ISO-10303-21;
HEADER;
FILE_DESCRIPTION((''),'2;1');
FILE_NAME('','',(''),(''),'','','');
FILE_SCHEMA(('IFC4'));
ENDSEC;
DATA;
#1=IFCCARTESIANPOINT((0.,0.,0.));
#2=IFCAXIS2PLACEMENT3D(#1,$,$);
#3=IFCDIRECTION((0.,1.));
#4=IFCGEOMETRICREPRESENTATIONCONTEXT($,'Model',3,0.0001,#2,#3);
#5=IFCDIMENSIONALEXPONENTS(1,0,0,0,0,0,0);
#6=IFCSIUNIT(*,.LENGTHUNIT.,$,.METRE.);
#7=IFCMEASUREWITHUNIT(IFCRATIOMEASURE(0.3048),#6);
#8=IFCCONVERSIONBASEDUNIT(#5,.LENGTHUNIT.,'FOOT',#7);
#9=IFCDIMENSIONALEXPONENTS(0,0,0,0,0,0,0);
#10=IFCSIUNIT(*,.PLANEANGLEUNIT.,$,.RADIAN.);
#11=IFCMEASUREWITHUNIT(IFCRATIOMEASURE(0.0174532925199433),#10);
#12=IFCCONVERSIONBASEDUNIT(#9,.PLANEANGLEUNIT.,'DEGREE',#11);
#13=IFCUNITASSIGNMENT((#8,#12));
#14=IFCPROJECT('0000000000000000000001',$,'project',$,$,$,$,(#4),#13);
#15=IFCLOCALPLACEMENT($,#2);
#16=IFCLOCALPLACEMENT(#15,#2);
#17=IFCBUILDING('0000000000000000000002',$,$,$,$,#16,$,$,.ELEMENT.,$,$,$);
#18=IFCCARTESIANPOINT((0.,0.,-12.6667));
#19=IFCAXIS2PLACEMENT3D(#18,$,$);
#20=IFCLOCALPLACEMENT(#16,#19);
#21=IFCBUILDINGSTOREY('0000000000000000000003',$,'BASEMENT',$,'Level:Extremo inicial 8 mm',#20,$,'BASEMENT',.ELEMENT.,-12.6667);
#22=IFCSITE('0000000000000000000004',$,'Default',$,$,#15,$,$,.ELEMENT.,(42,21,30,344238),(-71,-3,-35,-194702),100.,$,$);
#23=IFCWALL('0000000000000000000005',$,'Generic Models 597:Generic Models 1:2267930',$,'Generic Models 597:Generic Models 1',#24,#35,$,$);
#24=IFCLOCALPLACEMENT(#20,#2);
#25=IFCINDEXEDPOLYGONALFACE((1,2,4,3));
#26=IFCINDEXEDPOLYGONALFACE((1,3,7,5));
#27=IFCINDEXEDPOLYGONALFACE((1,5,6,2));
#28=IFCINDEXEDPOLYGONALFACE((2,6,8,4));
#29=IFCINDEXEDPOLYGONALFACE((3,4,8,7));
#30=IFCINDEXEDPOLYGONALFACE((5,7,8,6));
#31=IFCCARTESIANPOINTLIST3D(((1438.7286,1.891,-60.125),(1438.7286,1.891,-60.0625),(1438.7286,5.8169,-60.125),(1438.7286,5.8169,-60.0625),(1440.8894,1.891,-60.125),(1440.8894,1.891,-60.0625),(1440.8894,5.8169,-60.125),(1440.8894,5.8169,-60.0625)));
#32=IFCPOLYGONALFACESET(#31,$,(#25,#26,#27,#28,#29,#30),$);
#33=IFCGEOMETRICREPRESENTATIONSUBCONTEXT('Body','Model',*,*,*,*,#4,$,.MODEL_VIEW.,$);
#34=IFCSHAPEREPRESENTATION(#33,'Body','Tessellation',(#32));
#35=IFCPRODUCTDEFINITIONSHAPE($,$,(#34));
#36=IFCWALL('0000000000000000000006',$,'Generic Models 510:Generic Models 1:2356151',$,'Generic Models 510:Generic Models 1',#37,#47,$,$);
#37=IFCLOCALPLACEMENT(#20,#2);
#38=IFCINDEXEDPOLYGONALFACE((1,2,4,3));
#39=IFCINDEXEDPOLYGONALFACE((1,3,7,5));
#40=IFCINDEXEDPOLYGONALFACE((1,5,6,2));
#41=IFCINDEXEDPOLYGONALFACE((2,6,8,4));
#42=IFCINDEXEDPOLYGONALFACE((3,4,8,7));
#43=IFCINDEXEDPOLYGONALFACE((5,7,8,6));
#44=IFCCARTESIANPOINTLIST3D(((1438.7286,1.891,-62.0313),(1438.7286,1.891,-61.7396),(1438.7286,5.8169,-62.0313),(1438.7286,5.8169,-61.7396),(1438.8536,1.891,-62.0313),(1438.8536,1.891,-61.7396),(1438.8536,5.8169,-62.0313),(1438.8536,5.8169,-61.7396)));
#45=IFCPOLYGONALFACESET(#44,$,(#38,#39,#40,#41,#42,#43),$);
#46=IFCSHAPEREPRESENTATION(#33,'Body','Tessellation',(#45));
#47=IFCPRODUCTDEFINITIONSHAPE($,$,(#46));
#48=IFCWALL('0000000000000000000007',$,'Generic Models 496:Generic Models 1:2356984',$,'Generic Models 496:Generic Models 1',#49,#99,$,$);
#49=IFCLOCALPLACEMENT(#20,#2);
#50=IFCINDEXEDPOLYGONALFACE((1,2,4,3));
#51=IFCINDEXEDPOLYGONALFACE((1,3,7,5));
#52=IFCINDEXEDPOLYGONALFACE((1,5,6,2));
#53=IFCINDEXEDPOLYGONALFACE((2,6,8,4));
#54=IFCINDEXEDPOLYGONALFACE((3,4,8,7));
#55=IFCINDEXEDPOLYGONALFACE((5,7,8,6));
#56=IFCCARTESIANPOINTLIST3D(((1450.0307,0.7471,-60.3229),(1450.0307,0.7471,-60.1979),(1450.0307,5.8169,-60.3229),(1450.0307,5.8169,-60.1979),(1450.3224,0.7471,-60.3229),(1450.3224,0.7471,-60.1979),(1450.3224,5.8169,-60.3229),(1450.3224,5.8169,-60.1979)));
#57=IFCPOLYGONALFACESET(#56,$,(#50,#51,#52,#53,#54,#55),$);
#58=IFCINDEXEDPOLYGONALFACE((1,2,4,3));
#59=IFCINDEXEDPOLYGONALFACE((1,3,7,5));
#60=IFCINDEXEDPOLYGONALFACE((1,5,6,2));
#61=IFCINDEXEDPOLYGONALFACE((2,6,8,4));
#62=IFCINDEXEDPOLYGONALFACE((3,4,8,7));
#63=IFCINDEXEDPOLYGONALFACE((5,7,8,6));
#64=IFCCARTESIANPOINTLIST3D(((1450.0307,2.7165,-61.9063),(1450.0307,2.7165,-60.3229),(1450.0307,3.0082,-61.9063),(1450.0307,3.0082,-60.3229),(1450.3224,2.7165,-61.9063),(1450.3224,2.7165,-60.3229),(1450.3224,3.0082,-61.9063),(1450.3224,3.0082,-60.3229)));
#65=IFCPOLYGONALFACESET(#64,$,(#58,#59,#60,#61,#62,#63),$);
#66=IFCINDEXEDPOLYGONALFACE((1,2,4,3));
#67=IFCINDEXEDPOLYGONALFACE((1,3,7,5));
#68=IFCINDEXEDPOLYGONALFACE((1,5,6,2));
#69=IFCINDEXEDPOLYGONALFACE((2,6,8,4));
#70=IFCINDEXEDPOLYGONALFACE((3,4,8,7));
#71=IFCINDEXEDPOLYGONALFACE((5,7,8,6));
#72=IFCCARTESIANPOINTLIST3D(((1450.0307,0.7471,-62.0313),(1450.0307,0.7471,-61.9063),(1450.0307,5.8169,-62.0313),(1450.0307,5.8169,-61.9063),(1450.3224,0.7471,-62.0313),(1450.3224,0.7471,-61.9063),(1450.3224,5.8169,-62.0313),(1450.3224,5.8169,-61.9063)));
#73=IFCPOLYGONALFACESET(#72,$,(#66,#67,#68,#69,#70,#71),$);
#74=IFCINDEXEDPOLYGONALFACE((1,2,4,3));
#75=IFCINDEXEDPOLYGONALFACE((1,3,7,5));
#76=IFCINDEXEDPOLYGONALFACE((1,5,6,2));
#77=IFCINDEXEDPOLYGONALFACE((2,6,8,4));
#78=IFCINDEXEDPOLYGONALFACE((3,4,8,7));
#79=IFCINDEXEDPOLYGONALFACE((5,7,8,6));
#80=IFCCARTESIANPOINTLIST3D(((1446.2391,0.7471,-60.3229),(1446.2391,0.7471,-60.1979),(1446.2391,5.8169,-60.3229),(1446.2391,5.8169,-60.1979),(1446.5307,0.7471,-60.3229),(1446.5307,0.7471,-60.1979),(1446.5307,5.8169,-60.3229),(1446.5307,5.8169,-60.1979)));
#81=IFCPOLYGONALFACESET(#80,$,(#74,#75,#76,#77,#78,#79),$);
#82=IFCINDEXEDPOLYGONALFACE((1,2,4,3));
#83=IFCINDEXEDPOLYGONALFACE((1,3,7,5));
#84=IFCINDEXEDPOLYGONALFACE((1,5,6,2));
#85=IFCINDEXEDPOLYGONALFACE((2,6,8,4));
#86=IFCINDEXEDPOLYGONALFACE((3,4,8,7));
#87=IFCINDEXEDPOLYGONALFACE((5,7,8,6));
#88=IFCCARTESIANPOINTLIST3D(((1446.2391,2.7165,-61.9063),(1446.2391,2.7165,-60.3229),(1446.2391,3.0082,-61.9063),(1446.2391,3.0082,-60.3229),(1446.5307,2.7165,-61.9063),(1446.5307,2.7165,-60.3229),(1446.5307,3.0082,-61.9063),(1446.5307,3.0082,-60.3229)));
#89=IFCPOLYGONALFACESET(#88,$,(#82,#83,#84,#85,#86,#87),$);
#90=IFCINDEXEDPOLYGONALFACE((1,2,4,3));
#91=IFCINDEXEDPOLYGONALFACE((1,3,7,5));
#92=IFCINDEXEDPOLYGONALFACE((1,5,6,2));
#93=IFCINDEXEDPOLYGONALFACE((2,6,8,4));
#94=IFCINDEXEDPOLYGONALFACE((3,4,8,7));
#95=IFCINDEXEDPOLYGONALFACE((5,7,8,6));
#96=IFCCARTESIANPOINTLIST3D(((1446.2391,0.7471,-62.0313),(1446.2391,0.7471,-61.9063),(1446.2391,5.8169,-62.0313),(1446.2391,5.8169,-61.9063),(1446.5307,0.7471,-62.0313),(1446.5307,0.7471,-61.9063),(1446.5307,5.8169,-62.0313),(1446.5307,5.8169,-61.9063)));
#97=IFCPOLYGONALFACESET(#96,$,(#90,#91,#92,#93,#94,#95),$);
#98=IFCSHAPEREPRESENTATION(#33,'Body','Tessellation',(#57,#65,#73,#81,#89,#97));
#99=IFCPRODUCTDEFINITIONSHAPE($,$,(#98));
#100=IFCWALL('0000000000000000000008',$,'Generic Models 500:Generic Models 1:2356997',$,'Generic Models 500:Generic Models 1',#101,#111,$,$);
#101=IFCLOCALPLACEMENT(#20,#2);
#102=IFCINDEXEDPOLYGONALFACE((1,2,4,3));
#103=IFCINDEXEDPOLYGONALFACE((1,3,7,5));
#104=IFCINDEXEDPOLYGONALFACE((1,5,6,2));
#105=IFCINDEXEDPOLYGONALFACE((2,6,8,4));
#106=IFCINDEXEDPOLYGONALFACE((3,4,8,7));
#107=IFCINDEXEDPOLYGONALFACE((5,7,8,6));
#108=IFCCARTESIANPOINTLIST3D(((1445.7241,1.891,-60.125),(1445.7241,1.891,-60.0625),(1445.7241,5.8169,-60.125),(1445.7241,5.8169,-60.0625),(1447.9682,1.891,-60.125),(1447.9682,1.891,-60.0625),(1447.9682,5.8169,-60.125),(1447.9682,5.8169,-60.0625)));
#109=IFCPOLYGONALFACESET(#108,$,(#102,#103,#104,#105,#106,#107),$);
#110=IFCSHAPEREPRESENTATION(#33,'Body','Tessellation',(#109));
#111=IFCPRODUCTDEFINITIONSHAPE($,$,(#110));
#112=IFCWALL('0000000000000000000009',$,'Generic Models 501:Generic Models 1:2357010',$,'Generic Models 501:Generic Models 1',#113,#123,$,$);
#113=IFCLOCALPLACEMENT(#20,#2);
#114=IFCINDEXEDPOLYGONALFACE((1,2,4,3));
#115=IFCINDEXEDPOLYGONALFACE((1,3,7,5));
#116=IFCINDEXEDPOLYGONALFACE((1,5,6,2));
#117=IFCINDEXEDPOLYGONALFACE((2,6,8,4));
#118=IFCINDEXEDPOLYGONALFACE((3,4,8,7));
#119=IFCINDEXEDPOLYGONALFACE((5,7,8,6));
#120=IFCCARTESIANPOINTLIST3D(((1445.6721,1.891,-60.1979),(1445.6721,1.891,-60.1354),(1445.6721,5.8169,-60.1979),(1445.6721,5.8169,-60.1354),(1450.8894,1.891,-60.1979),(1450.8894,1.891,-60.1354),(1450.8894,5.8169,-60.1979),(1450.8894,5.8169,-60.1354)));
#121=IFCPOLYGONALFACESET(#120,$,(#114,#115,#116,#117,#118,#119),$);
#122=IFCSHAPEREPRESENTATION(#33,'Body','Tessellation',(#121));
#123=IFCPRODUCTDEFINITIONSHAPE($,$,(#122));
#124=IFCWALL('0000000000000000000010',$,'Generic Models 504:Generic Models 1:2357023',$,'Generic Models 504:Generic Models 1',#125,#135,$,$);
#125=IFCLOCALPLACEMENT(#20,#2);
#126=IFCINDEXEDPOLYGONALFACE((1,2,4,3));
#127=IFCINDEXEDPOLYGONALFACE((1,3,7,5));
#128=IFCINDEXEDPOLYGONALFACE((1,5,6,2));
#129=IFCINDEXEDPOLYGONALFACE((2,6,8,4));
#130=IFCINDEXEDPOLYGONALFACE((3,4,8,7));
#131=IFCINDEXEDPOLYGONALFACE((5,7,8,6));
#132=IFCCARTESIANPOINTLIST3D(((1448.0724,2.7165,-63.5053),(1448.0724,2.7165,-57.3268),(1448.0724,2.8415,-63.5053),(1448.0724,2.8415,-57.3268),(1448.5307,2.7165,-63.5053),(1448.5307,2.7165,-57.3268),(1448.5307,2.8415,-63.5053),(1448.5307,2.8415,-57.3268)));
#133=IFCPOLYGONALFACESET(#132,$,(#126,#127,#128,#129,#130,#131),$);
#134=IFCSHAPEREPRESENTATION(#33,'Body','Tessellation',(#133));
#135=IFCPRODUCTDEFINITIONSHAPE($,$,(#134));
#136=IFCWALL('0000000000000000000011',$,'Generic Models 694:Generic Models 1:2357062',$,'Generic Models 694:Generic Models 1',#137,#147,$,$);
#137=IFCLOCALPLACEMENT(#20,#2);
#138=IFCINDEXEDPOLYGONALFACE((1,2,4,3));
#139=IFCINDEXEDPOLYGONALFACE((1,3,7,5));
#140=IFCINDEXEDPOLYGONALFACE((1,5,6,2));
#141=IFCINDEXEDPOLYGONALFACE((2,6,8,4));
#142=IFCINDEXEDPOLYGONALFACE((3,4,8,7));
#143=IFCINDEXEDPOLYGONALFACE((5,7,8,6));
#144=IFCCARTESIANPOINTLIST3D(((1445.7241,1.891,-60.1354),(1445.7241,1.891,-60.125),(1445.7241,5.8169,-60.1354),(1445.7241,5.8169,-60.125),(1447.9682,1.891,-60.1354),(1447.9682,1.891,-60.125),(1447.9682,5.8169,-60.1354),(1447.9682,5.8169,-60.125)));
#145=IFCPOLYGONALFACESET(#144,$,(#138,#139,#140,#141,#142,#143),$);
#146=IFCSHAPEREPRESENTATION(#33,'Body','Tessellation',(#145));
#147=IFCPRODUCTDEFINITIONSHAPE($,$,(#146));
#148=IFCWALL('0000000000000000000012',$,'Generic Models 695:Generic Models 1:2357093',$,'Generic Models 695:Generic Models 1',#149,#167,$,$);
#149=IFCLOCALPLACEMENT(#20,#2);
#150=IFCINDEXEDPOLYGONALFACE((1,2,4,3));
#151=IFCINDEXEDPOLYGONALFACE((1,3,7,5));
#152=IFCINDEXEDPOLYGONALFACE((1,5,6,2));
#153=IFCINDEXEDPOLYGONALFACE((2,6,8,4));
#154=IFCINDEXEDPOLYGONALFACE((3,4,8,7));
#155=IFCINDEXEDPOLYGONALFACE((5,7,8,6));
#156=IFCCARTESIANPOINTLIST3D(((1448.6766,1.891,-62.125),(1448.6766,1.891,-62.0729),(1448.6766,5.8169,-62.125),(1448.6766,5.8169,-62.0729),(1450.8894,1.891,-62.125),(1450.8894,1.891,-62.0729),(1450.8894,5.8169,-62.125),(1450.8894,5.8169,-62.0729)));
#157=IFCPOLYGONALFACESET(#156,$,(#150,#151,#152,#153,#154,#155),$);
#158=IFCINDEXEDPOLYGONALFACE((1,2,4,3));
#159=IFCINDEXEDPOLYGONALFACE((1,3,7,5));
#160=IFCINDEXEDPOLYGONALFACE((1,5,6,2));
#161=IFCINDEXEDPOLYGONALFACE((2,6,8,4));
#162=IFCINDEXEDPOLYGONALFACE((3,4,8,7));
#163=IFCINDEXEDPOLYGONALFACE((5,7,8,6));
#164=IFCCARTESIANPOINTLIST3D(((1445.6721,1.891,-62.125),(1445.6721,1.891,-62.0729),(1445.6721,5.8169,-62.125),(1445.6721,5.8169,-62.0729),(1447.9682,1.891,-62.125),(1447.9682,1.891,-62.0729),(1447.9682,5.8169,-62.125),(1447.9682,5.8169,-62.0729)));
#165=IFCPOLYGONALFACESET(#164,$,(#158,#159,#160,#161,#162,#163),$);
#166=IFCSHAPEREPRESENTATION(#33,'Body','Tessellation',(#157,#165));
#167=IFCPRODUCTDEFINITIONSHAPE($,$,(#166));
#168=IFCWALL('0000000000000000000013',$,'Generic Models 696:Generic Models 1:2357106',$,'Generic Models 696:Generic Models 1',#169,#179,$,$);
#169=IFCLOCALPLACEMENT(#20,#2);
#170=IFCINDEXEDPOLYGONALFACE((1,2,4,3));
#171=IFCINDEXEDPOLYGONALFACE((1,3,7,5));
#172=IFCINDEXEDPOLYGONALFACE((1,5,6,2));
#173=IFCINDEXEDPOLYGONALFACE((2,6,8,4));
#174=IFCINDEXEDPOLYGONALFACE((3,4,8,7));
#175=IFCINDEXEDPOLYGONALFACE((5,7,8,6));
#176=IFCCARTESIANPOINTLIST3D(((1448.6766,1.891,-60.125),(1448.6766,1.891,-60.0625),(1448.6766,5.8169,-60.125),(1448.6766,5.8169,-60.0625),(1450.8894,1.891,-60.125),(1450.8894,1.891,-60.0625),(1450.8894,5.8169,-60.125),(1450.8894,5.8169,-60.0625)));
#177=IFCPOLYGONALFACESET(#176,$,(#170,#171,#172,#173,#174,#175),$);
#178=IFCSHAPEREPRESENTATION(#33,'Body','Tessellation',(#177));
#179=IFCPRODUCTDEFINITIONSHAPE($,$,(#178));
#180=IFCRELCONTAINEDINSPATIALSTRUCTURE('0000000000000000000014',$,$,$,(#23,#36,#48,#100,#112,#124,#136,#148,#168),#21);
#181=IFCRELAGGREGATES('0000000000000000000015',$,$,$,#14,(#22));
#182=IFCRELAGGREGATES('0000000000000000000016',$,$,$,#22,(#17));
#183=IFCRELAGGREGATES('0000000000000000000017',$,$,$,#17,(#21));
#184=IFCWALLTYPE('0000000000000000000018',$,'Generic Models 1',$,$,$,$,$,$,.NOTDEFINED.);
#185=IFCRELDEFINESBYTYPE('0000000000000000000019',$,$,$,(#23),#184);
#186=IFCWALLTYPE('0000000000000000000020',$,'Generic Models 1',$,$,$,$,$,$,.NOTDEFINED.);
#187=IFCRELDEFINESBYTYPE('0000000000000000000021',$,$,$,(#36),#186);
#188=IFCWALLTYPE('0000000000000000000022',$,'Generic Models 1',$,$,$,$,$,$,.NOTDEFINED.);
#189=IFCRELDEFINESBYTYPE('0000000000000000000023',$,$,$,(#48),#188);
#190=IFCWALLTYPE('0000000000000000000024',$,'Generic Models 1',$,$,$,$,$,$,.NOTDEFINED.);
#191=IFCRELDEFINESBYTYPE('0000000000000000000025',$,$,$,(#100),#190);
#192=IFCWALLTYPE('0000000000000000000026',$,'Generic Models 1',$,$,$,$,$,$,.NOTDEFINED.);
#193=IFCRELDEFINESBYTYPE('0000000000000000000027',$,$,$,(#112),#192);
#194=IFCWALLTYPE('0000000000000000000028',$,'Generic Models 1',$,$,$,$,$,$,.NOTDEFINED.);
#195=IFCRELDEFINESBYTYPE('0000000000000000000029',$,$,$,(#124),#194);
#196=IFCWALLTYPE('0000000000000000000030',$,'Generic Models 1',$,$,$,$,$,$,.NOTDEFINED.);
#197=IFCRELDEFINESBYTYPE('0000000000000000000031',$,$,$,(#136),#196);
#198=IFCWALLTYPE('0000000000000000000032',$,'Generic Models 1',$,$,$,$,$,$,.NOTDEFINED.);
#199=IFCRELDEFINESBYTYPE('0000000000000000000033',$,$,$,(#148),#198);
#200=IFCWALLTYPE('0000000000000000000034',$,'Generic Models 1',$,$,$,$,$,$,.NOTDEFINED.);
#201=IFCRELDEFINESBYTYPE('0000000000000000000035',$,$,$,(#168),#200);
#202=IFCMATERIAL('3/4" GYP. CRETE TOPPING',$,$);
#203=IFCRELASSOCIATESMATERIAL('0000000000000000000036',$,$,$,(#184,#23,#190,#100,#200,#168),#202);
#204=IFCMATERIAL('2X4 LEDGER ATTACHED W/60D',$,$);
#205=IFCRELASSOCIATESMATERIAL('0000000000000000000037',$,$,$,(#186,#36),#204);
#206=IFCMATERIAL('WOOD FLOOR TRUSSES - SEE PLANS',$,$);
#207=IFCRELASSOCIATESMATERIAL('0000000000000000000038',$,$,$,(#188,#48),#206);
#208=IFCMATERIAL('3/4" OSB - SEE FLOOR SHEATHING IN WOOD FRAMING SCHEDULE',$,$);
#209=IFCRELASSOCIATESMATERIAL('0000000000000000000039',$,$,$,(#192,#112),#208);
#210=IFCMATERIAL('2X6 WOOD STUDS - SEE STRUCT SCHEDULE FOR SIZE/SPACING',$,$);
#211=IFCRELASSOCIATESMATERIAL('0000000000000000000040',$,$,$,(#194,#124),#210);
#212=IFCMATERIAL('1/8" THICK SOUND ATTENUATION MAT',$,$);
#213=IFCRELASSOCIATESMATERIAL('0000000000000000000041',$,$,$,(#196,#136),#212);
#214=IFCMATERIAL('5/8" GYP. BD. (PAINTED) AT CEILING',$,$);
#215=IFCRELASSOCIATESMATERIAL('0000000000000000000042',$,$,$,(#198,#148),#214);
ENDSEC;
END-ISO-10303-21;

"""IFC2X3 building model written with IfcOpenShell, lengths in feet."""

from ifc_helpers import new_model, entity, si_unit, converted_unit, direction, frame, frame_2d, origin, origin_2d_with_axis, place, context, subcontext, project, spatial, rectangle, extrude, material, type_object, element, save


model = new_model("IFC2X3")

# Units and contexts
model_context = context("Model", 3, precision=0.0001, world=origin(), true_north=direction((0.0, 1.0)))
body_context = subcontext(model_context, "Body", "Model", "MODEL_VIEW")
ifc_project = project(units=[converted_unit("LENGTHUNIT", "FOOT", entity("IfcRatioMeasure", 0.3048), si_unit("LENGTHUNIT", "METRE"), dimensions=[1, 0, 0, 0, 0, 0, 0]), converted_unit("PLANEANGLEUNIT", "DEGREE", entity("IfcRatioMeasure", 0.0174532925199433), si_unit("PLANEANGLEUNIT", "RADIAN"), dimensions=[0, 0, 0, 0, 0, 0, 0])], contexts=[model_context])

# Site, building, storey
site_placement = place(None, origin())
site = spatial("IfcSite", under=ifc_project, at=site_placement, Name="Default", CompositionType="ELEMENT", RefLatitude=(42, 21, 30, 344238), RefLongitude=(-71, -3, -35, -194702), RefElevation=100.0)
building_placement = place(site_placement, origin())
building = spatial("IfcBuilding", under=site, at=building_placement, CompositionType="ELEMENT")
storey_placement = place(building_placement, frame((0.0, 0.0, -12.6667)))
storey = spatial("IfcBuildingStorey", under=building, at=storey_placement, Name="BASEMENT", ObjectType="Level:Extremo inicial 8 mm", LongName="BASEMENT", CompositionType="ELEMENT", Elevation=-12.6667)

# Walls
ifc_material_1 = material(Name="3/4\" GYP. CRETE TOPPING")
wall_type_1 = type_object("IfcWallType", Name="Generic Models 1", PredefinedType="NOTDEFINED", material=ifc_material_1)
wall_1_placement = place(storey_placement, frame((1438.7286, 1.891, -60.125), z_axis=(0.0, 0.0, 1.0), x_axis=(0.0, 1.0, 0.0)))
element("IfcWall", 1, at=wall_1_placement, inside=storey, type_object=wall_type_1, material=ifc_material_1, Name="Generic Models 597:Generic Models 1:2267930", ObjectType="Generic Models 597:Generic Models 1", context=body_context, shape_type="SweptSolid", body=[
    extrude(rectangle(XDim=3.9258, YDim=2.1608, at=origin_2d_with_axis()), frame((1.9629, -1.0804, 0.0)), (0.0, 0.0, 1.0), 0.0625),
])
ifc_material_2 = material(Name="2X4 LEDGER ATTACHED W/60D")
wall_type_2 = type_object("IfcWallType", Name="Generic Models 1", PredefinedType="NOTDEFINED", material=ifc_material_2)
wall_2_placement = place(storey_placement, frame((1438.7286, 1.891, -62.0313), z_axis=(0.0, 0.0, 1.0), x_axis=(0.0, 1.0, 0.0)))
element("IfcWall", 2, at=wall_2_placement, inside=storey, type_object=wall_type_2, material=ifc_material_2, Name="Generic Models 510:Generic Models 1:2356151", ObjectType="Generic Models 510:Generic Models 1", context=body_context, shape_type="SweptSolid", body=[
    extrude(rectangle(XDim=3.9258, YDim=0.125, at=origin_2d_with_axis()), frame((1.9629, -0.0625, 0.0)), (0.0, 0.0, 1.0), 0.2917),
])
ifc_material_3 = material(Name="WOOD FLOOR TRUSSES - SEE PLANS")
wall_type_3 = type_object("IfcWallType", Name="Generic Models 1", PredefinedType="NOTDEFINED", material=ifc_material_3)
wall_3_placement = place(storey_placement, frame((1446.2391, 0.7471, -62.0313), z_axis=(0.0, 0.0, 1.0), x_axis=(0.0, 1.0, 0.0)))
element("IfcWall", 3, at=wall_3_placement, inside=storey, type_object=wall_type_3, material=ifc_material_3, Name="Generic Models 496:Generic Models 1:2356984", ObjectType="Generic Models 496:Generic Models 1", context=body_context, shape_type="SweptSolid", body=[
    extrude(rectangle(XDim=5.0697, YDim=0.2917, at=frame_2d((0.0, 0.0), x_axis=(1.0, 0.0))), frame((2.5349, -3.9375, 1.7083)), (0.0, 0.0, 1.0), 0.125),
    extrude(rectangle(XDim=0.2917, YDim=0.2917, at=frame_2d((0.0, 0.0), x_axis=(1.0, 0.0))), frame((2.1152, -3.9375, 0.125)), (0.0, 0.0, 1.0), 1.5833),
    extrude(rectangle(XDim=5.0697, YDim=0.2917, at=frame_2d((0.0, 0.0), x_axis=(1.0, 0.0))), frame((2.5349, -3.9375, 0.0)), (0.0, 0.0, 1.0), 0.125),
    extrude(rectangle(XDim=5.0697, YDim=0.2917, at=frame_2d((0.0, 0.0), x_axis=(1.0, 0.0))), frame((2.5349, -0.1458, 1.7083)), (0.0, 0.0, 1.0), 0.125),
    extrude(rectangle(XDim=0.2917, YDim=0.2917, at=frame_2d((0.0, 0.0), x_axis=(1.0, 0.0))), frame((2.1152, -0.1458, 0.125)), (0.0, 0.0, 1.0), 1.5833),
    extrude(rectangle(XDim=5.0697, YDim=0.2917, at=frame_2d((0.0, 0.0), x_axis=(1.0, 0.0))), frame((2.5349, -0.1458, 0.0)), (0.0, 0.0, 1.0), 0.125),
])
wall_type_4 = type_object("IfcWallType", Name="Generic Models 1", PredefinedType="NOTDEFINED", material=ifc_material_1)
wall_4_placement = place(storey_placement, frame((1445.7241, 1.891, -60.125), z_axis=(0.0, 0.0, 1.0), x_axis=(0.0, 1.0, 0.0)))
element("IfcWall", 4, at=wall_4_placement, inside=storey, type_object=wall_type_4, material=ifc_material_1, Name="Generic Models 500:Generic Models 1:2356997", ObjectType="Generic Models 500:Generic Models 1", context=body_context, shape_type="SweptSolid", body=[
    extrude(rectangle(XDim=3.9258, YDim=2.2441, at=frame_2d((0.0, 0.0), x_axis=(1.0, 0.0))), frame((1.9629, -1.122, 0.0)), (0.0, 0.0, 1.0), 0.0625),
])
ifc_material_4 = material(Name="3/4\" OSB - SEE FLOOR SHEATHING IN WOOD FRAMING SCHEDULE")
wall_type_5 = type_object("IfcWallType", Name="Generic Models 1", PredefinedType="NOTDEFINED", material=ifc_material_4)
wall_5_placement = place(storey_placement, frame((1445.6721, 1.891, -60.1979)))
element("IfcWall", 5, at=wall_5_placement, inside=storey, type_object=wall_type_5, material=ifc_material_4, Name="Generic Models 501:Generic Models 1:2357010", ObjectType="Generic Models 501:Generic Models 1", context=body_context, shape_type="SweptSolid", body=[
    extrude(rectangle(XDim=3.9258, YDim=5.2173, at=frame_2d((0.0, 0.0), x_axis=(1.0, 0.0))), frame((2.6087, 1.9629, 0.0), z_axis=(0.0, 0.0, 1.0), x_axis=(0.0, 1.0, 0.0)), (0.0, 0.0, 1.0), 0.0625),
])
ifc_material_5 = material(Name="2X6 WOOD STUDS - SEE STRUCT SCHEDULE FOR SIZE/SPACING")
wall_type_6 = type_object("IfcWallType", Name="Generic Models 1", PredefinedType="NOTDEFINED", material=ifc_material_5)
wall_6_placement = place(storey_placement, frame((1448.0724, 2.7165, -63.5053)))
element("IfcWall", 6, at=wall_6_placement, inside=storey, type_object=wall_type_6, material=ifc_material_5, Name="Generic Models 504:Generic Models 1:2357023", ObjectType="Generic Models 504:Generic Models 1", context=body_context, shape_type="SweptSolid", body=[
    extrude(rectangle(XDim=0.125, YDim=0.4583, at=frame_2d((0.0, 0.0), x_axis=(1.0, 0.0))), frame((0.2292, 0.0625, 0.0), z_axis=(0.0, 0.0, 1.0), x_axis=(0.0, 1.0, 0.0)), (0.0, 0.0, 1.0), 6.1785),
])
ifc_material_6 = material(Name="1/8\" THICK SOUND ATTENUATION MAT")
wall_type_7 = type_object("IfcWallType", Name="Generic Models 1", PredefinedType="NOTDEFINED", material=ifc_material_6)
wall_7_placement = place(storey_placement, frame((1445.7241, 1.891, -60.1354), z_axis=(0.0, 0.0, 1.0), x_axis=(0.0, 1.0, 0.0)))
element("IfcWall", 7, at=wall_7_placement, inside=storey, type_object=wall_type_7, material=ifc_material_6, Name="Generic Models 694:Generic Models 1:2357062", ObjectType="Generic Models 694:Generic Models 1", context=body_context, shape_type="SweptSolid", body=[
    extrude(rectangle(XDim=3.9258, YDim=2.2441, at=frame_2d((0.0, 0.0), x_axis=(1.0, 0.0))), frame((1.9629, -1.122, 0.0)), (0.0, 0.0, 1.0), 0.0104),
])
ifc_material_7 = material(Name="5/8\" GYP. BD. (PAINTED) AT CEILING")
wall_type_8 = type_object("IfcWallType", Name="Generic Models 1", PredefinedType="NOTDEFINED", material=ifc_material_7)
wall_8_placement = place(storey_placement, frame((1445.6721, 1.891, -62.125)))
element("IfcWall", 8, at=wall_8_placement, inside=storey, type_object=wall_type_8, material=ifc_material_7, Name="Generic Models 695:Generic Models 1:2357093", ObjectType="Generic Models 695:Generic Models 1", context=body_context, shape_type="SweptSolid", body=[
    extrude(rectangle(XDim=3.9258, YDim=2.2128, at=frame_2d((0.0, 0.0), x_axis=(1.0, 0.0))), frame((4.1109, 1.9629, 0.0), z_axis=(0.0, 0.0, 1.0), x_axis=(0.0, 1.0, 0.0)), (0.0, 0.0, 1.0), 0.0521),
    extrude(rectangle(XDim=3.9258, YDim=2.2962, at=frame_2d((0.0, 0.0), x_axis=(1.0, 0.0))), frame((1.1481, 1.9629, 0.0), z_axis=(0.0, 0.0, 1.0), x_axis=(0.0, 1.0, 0.0)), (0.0, 0.0, 1.0), 0.0521),
])
wall_type_9 = type_object("IfcWallType", Name="Generic Models 1", PredefinedType="NOTDEFINED", material=ifc_material_1)
wall_9_placement = place(storey_placement, frame((1448.6766, 1.891, -60.125), z_axis=(0.0, 0.0, 1.0), x_axis=(0.0, 1.0, 0.0)))
element("IfcWall", 9, at=wall_9_placement, inside=storey, type_object=wall_type_9, material=ifc_material_1, Name="Generic Models 696:Generic Models 1:2357106", ObjectType="Generic Models 696:Generic Models 1", context=body_context, shape_type="SweptSolid", body=[
    extrude(rectangle(XDim=3.9258, YDim=2.2128, at=frame_2d((0.0, 0.0), x_axis=(1.0, 0.0))), frame((1.9629, -1.1064, 0.0)), (0.0, 0.0, 1.0), 0.0625),
])

save(model, "model.ifc")
